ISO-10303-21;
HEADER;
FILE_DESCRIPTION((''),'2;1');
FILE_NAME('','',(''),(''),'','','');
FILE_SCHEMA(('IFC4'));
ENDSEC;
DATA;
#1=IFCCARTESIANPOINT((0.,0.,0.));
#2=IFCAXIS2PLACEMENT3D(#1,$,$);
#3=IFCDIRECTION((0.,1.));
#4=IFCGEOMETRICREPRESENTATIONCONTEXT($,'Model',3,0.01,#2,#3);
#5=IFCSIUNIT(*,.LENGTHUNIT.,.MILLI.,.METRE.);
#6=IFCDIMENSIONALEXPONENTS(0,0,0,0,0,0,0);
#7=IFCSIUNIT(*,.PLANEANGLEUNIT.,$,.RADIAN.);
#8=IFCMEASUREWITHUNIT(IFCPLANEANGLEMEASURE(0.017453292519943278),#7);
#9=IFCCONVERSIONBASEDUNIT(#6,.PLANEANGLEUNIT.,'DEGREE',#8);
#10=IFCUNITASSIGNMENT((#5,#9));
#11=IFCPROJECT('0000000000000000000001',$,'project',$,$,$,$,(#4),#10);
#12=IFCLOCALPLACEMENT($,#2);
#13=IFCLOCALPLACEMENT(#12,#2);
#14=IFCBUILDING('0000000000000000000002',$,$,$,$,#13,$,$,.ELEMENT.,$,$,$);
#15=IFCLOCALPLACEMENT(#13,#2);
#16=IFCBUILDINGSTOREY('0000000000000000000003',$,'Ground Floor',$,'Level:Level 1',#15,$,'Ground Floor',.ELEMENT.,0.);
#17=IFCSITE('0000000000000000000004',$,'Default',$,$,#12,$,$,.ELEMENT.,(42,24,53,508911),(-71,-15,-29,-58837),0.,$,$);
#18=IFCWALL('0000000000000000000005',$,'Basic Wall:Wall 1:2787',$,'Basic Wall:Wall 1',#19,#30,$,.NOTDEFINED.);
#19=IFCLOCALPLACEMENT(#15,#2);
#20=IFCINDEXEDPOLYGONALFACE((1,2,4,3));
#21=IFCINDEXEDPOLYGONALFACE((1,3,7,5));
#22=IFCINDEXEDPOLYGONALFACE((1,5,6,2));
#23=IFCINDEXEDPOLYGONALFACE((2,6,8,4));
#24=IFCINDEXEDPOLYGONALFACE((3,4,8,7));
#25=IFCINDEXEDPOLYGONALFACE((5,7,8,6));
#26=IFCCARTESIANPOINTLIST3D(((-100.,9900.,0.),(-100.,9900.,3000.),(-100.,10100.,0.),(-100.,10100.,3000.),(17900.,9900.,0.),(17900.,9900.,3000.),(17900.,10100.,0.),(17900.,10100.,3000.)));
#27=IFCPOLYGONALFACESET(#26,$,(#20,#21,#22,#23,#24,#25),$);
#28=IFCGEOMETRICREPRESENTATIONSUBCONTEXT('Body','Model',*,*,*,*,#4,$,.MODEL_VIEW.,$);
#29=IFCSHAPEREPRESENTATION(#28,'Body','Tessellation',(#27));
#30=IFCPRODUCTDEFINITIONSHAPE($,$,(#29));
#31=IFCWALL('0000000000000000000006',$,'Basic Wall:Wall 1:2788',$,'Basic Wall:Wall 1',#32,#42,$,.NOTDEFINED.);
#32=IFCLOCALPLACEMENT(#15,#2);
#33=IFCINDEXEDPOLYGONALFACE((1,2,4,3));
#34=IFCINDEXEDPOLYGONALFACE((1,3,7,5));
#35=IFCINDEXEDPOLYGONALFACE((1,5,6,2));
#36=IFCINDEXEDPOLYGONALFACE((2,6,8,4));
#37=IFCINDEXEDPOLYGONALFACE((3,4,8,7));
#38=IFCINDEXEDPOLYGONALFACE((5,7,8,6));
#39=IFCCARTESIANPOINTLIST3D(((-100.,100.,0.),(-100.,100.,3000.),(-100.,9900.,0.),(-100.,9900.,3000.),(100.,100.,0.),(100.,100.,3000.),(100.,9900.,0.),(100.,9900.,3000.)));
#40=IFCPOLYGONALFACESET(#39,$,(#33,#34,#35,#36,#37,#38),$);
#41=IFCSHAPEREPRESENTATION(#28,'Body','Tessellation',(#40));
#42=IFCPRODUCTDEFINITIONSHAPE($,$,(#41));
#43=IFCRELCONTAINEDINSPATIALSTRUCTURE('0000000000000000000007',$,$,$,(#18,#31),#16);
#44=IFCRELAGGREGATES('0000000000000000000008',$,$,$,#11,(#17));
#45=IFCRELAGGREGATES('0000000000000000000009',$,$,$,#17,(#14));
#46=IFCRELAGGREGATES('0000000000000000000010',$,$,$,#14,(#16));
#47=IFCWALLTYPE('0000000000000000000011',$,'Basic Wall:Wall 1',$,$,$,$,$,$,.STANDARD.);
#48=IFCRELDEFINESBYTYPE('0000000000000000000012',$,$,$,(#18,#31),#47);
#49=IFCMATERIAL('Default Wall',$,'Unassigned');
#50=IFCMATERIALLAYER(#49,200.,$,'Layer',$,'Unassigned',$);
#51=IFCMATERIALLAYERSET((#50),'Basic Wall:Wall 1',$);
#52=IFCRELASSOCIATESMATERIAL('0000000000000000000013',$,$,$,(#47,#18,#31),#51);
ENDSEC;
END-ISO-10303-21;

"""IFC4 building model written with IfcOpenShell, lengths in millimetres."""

from ifc_helpers import new_model, entity, si_unit, converted_unit, direction, frame, frame_2d, origin, place, context, subcontext, project, spatial, rectangle, extrude, material, layer, layer_set, layer_usage, type_object, element, save


model = new_model("IFC4")

# Units and contexts
model_context = context("Model", 3, precision=0.01, world=origin(), true_north=direction((0.0, 1.0)))
body_context = subcontext(model_context, "Body", "Model", "MODEL_VIEW")
ifc_project = project(units=[si_unit("LENGTHUNIT", "METRE", prefix="MILLI"), converted_unit("PLANEANGLEUNIT", "DEGREE", entity("IfcPlaneAngleMeasure", 0.017453292519943278), si_unit("PLANEANGLEUNIT", "RADIAN"), dimensions=[0, 0, 0, 0, 0, 0, 0])], contexts=[model_context])

# Site, building, storey
site_placement = place(None, origin())
site = spatial("IfcSite", under=ifc_project, at=site_placement, Name="Default", CompositionType="ELEMENT", RefLatitude=(42, 24, 53, 508911), RefLongitude=(-71, -15, -29, -58837), RefElevation=0.0)
building_placement = place(site_placement, origin())
building = spatial("IfcBuilding", under=site, at=building_placement, CompositionType="ELEMENT")
storey_placement = place(building_placement, origin())
storey = spatial("IfcBuildingStorey", under=building, at=storey_placement, Name="Ground Floor", ObjectType="Level:Level 1", LongName="Ground Floor", CompositionType="ELEMENT", Elevation=0.0)

# Shared definitions
ifc_material_1 = material(Name="Default Wall", Category="Unassigned")

# Walls
ifc_layer_1 = layer(ifc_material_1, 200.0, Name="Layer", Category="Unassigned")
ifc_layer_set_1 = layer_set([ifc_layer_1], Name="Basic Wall:Wall 1")
wall_type = type_object("IfcWallType", Name="Basic Wall:Wall 1", PredefinedType="STANDARD", material=ifc_layer_set_1)
ifc_layer_usage_1 = layer_usage(ifc_layer_set_1, "AXIS2", "NEGATIVE", 100.0)
wall_1_placement = place(storey_placement, frame((17900.0, 10000.0, 0.0), z_axis=(0.0, 0.0, 1.0), x_axis=(-1.0, 0.0, 0.0)))
element("IfcWall", 1, at=wall_1_placement, inside=storey, type_object=wall_type, material=ifc_layer_usage_1, Name="Basic Wall:Wall 1:2787", ObjectType="Basic Wall:Wall 1", PredefinedType="NOTDEFINED", context=body_context, shape_type="SweptSolid", body=[
    extrude(rectangle(XDim=18000.0, YDim=200.0, at=frame_2d((9000.0, 0.0), x_axis=(-1.0, 0.0))), origin(), (0.0, 0.0, 1.0), 3000.0),
])
ifc_layer_usage_2 = layer_usage(ifc_layer_set_1, "AXIS2", "NEGATIVE", 100.0)
wall_2_placement = place(storey_placement, frame((0.0, 9900.0, 0.0), z_axis=(0.0, 0.0, 1.0), x_axis=(0.0, -1.0, 0.0)))
element("IfcWall", 2, at=wall_2_placement, inside=storey, type_object=wall_type, material=ifc_layer_usage_2, Name="Basic Wall:Wall 1:2788", ObjectType="Basic Wall:Wall 1", PredefinedType="NOTDEFINED", context=body_context, shape_type="SweptSolid", body=[
    extrude(rectangle(XDim=9800.0, YDim=200.0, at=frame_2d((4900.0, 0.0), x_axis=(-1.0, 0.0))), origin(), (0.0, 0.0, 1.0), 3000.0),
])

save(model, "model.ifc")
